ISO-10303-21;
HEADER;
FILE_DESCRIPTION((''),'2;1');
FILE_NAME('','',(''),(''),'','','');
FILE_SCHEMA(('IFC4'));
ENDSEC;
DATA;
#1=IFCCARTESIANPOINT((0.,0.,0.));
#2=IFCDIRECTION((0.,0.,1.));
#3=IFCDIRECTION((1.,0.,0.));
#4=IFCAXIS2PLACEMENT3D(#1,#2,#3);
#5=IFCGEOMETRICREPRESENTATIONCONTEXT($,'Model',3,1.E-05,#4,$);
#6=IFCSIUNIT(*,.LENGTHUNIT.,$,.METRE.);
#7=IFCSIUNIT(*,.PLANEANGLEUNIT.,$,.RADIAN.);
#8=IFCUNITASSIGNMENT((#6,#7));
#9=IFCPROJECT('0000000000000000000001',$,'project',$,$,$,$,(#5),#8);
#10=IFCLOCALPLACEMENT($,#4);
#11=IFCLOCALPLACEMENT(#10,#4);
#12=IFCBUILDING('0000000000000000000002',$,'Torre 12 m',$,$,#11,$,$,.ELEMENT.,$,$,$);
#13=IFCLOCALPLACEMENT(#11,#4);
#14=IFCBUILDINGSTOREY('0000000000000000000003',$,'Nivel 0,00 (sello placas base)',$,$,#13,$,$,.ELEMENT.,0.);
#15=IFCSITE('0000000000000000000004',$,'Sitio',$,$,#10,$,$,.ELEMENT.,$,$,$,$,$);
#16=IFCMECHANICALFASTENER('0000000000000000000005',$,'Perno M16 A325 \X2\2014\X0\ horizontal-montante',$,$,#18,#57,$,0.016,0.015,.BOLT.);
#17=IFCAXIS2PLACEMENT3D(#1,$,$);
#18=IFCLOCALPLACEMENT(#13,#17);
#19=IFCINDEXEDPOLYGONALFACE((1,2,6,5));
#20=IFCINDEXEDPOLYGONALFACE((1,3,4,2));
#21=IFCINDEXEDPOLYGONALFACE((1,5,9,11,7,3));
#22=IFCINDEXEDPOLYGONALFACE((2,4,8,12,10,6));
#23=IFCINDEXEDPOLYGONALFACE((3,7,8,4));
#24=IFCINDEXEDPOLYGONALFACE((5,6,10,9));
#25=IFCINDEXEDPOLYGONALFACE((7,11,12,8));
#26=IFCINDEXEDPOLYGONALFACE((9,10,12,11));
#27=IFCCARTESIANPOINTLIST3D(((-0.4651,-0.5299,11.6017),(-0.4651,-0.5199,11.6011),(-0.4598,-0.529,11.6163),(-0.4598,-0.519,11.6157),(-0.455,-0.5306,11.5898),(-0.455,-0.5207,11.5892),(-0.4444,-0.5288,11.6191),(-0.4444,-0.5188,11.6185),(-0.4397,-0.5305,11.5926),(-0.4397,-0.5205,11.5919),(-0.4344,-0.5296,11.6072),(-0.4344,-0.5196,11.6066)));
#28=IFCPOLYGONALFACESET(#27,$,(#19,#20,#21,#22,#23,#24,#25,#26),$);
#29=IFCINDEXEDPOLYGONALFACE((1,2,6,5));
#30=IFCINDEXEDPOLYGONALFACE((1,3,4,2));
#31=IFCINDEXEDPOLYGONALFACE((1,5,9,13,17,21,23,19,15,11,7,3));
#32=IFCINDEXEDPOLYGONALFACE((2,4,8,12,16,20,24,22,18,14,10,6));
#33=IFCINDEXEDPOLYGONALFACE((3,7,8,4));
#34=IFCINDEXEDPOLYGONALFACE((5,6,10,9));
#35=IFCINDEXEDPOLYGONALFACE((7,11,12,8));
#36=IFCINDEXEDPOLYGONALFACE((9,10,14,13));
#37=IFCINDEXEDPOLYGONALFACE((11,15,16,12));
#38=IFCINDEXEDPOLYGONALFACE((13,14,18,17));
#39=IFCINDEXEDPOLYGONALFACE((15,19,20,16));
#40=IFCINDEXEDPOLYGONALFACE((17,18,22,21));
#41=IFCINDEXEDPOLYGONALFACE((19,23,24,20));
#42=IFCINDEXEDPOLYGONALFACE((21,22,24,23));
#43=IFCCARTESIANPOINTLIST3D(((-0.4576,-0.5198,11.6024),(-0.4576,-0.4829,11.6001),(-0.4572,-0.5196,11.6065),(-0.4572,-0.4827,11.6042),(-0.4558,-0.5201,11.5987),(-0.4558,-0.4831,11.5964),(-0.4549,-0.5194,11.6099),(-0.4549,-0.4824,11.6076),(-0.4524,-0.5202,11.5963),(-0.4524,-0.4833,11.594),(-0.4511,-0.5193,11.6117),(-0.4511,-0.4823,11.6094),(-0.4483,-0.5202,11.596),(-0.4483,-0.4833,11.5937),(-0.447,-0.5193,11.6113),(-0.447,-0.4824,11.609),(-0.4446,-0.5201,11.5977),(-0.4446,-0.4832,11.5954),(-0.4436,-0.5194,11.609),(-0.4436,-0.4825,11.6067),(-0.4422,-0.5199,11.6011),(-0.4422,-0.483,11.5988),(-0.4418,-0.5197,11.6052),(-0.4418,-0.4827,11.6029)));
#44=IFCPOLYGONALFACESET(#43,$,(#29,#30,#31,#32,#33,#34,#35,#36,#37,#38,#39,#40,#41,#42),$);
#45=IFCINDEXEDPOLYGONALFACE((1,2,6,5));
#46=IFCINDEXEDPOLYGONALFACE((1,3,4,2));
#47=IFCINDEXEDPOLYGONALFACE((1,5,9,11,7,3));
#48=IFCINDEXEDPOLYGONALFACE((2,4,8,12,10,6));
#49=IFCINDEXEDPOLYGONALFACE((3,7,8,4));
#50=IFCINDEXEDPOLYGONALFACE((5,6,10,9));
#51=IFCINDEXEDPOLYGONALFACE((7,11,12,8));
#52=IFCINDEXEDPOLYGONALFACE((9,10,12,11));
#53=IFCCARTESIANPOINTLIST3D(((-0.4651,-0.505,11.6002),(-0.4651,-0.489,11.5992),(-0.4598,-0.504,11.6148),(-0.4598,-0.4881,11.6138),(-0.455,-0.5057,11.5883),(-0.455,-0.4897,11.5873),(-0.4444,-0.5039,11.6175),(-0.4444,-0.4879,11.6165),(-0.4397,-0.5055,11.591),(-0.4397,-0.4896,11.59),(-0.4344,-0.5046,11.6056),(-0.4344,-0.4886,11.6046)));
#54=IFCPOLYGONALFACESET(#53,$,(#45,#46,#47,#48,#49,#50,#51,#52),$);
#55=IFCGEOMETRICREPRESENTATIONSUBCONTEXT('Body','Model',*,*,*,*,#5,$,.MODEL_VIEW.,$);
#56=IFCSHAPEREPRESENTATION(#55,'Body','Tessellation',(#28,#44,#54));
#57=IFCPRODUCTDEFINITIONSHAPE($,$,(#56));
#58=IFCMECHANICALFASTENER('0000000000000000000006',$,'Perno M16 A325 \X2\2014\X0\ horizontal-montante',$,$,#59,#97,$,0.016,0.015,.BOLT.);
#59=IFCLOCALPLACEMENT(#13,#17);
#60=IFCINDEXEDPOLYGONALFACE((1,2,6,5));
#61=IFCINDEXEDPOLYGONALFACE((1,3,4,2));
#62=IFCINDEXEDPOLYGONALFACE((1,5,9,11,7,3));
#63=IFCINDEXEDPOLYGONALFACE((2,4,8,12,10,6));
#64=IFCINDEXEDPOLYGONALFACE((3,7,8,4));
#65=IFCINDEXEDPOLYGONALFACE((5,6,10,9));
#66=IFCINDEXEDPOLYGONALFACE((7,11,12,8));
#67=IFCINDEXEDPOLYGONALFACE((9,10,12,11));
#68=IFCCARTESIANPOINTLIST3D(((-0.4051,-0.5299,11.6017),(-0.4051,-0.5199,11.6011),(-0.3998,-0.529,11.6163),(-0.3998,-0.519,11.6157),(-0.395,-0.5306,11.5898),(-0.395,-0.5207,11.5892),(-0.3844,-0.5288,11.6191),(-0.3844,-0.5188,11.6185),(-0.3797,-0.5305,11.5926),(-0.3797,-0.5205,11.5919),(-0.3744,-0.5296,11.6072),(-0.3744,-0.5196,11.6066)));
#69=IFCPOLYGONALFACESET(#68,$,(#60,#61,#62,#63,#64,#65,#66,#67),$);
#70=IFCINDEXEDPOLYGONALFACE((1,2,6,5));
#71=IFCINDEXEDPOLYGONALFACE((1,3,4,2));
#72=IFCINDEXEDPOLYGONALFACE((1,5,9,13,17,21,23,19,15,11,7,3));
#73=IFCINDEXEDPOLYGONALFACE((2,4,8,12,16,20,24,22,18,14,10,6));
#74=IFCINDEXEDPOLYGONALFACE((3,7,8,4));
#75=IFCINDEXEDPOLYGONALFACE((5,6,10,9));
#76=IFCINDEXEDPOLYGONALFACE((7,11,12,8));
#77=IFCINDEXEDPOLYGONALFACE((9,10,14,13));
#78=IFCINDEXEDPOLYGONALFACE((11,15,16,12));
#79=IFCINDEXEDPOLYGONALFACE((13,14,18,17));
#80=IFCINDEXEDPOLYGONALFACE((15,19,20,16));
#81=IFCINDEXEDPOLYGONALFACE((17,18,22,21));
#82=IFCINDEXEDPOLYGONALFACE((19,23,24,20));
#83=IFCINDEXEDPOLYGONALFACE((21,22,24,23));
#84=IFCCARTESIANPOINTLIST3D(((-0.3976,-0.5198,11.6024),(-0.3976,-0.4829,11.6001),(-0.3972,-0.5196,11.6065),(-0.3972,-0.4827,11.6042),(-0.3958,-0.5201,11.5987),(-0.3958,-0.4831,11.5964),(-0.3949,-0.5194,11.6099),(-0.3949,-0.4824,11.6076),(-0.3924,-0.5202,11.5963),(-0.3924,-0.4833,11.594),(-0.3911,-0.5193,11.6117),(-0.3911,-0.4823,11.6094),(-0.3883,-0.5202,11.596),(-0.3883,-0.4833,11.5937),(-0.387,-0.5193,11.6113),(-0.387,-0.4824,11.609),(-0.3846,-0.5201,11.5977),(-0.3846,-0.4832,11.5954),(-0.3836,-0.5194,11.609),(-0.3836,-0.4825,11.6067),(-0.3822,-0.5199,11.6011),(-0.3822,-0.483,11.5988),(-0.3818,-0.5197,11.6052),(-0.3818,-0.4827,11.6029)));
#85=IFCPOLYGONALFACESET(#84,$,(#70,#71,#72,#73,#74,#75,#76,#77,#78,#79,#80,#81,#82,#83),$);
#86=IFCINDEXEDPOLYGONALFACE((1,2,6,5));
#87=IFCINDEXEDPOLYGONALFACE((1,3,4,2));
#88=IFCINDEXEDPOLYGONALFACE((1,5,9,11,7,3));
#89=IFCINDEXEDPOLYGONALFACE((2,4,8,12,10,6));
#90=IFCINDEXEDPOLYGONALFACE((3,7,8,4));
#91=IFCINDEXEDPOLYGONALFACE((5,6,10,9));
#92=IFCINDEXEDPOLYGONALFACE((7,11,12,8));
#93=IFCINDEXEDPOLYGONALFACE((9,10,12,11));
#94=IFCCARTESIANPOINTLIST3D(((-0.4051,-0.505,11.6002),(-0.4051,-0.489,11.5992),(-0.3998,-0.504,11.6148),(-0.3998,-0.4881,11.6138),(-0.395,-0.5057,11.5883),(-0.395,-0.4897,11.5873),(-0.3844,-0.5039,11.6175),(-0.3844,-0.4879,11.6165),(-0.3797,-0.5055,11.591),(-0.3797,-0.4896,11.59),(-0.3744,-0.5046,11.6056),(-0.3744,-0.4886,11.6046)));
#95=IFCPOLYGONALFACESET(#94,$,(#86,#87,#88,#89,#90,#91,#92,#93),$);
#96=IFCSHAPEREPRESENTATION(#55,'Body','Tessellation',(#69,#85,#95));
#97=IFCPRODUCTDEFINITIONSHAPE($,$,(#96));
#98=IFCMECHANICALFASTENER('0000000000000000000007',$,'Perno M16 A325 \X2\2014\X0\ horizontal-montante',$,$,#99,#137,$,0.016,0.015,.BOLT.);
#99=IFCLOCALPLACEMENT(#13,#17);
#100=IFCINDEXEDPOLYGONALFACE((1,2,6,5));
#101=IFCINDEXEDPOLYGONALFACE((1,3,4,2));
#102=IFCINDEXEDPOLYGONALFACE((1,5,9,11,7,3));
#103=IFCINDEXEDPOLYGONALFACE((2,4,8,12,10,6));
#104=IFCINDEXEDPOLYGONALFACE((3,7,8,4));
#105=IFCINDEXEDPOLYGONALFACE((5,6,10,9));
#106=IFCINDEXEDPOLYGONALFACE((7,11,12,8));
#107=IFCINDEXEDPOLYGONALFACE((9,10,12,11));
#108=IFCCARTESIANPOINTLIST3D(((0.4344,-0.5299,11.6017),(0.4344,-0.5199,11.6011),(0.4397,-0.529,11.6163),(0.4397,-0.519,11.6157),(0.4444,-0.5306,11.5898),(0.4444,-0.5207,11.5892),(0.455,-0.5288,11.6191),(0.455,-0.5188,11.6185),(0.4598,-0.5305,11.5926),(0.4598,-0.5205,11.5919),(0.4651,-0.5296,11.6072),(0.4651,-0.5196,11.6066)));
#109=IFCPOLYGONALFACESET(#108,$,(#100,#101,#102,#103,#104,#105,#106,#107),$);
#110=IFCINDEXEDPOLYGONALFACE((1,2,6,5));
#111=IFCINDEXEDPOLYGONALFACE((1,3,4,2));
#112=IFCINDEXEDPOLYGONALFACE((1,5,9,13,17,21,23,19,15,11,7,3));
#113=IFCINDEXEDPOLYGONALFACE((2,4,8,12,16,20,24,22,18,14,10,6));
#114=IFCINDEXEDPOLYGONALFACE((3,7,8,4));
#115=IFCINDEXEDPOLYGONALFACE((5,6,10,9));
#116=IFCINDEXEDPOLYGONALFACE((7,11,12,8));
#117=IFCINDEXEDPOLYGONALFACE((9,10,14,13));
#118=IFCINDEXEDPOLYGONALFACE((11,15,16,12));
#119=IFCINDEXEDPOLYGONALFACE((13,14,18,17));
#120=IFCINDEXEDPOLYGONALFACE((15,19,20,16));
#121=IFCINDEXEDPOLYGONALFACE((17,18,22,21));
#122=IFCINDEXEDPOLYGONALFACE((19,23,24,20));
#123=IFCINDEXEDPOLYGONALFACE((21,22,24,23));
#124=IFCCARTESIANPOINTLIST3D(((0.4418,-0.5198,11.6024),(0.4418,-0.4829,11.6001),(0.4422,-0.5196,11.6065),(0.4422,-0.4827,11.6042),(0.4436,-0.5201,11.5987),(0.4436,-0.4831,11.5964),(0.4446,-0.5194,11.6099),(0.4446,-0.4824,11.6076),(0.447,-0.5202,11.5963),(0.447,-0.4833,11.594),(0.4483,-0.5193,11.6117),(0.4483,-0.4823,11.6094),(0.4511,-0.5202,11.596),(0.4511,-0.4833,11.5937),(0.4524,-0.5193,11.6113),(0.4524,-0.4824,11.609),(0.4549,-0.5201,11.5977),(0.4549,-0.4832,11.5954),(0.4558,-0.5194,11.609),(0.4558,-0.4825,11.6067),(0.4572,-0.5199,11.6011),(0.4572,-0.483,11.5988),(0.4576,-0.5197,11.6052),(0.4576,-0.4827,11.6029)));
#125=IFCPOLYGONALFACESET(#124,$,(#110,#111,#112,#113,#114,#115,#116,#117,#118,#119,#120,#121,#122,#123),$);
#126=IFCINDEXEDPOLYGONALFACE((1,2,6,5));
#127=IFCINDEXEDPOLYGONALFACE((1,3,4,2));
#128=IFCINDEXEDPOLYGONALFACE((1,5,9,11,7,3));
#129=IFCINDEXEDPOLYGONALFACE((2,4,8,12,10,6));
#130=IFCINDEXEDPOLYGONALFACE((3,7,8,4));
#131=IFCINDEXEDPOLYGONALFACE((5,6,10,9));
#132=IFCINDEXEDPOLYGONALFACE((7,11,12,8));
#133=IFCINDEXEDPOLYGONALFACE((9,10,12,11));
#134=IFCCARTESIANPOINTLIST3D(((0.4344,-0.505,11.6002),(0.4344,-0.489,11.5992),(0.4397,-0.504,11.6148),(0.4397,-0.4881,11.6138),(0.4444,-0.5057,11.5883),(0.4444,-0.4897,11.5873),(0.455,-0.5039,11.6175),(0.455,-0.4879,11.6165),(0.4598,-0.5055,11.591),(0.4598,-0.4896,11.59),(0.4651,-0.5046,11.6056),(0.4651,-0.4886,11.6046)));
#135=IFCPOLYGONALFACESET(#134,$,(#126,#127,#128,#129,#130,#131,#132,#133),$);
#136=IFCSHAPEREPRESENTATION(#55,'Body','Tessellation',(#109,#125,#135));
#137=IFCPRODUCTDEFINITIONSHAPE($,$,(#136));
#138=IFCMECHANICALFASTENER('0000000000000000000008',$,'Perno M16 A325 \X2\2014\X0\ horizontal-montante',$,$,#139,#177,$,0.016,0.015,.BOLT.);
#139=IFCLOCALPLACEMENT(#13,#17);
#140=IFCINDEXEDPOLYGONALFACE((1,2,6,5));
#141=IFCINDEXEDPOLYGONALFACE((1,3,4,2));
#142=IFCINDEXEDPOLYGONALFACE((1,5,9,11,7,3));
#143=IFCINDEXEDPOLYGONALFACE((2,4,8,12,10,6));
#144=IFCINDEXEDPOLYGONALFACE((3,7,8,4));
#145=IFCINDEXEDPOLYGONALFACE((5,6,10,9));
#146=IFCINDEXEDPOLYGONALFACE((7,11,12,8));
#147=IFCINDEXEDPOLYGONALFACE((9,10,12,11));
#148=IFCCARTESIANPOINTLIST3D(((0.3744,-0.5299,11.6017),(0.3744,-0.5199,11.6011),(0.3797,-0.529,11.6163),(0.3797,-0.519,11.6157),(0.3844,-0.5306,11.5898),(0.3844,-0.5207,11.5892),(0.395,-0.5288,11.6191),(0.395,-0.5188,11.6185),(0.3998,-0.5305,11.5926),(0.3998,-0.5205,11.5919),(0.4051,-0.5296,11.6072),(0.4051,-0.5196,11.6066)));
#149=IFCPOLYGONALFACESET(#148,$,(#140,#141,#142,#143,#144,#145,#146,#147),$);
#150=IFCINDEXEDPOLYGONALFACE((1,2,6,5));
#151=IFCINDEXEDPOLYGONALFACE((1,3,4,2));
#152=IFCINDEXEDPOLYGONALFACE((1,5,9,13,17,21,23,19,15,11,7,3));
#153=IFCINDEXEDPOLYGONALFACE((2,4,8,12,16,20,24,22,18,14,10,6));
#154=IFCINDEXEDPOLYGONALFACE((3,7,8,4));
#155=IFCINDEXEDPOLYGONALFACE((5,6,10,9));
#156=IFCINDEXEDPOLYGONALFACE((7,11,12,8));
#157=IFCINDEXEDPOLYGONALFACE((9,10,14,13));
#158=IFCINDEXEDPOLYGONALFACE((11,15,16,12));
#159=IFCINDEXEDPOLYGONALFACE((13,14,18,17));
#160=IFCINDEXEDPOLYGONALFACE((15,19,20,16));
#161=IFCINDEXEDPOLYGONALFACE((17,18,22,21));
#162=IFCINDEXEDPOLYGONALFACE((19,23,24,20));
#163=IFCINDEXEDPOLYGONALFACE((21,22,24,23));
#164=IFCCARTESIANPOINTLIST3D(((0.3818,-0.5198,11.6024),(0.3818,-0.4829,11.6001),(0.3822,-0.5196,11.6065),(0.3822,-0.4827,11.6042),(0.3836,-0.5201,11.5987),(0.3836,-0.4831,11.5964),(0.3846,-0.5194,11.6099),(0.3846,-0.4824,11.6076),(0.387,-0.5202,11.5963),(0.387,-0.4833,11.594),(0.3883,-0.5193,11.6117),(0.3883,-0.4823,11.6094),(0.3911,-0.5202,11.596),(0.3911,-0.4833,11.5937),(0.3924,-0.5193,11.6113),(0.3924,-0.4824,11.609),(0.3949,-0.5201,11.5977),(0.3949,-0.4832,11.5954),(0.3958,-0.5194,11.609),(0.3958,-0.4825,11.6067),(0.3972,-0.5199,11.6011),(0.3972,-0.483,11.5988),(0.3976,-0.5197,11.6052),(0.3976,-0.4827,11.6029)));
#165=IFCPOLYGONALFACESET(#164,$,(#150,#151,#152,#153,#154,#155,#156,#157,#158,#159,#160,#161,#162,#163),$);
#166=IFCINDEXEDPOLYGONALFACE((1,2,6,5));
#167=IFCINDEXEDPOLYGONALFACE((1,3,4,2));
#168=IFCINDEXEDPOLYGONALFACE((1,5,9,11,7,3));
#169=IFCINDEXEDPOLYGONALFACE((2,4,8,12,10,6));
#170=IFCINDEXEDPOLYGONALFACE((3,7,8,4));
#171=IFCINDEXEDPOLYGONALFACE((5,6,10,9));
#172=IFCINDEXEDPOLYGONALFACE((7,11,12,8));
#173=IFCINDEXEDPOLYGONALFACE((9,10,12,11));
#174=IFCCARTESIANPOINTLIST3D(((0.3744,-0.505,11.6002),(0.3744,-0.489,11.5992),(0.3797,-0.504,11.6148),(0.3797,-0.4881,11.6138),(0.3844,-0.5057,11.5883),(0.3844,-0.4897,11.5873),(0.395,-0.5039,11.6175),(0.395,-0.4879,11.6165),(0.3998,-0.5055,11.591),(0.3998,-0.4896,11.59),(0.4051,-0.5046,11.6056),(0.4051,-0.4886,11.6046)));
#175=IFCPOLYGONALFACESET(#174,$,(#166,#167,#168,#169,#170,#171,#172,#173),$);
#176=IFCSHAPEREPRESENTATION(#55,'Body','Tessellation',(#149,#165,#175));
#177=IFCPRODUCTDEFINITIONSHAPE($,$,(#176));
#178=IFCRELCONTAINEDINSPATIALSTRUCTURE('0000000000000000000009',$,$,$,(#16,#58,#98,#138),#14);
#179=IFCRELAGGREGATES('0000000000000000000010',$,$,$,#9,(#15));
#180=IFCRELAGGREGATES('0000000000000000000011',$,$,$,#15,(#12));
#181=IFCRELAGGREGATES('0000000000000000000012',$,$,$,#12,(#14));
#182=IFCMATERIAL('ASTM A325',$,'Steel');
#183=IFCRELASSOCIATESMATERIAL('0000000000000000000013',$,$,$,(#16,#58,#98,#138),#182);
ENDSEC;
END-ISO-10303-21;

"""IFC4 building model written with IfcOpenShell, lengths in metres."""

from ifc_helpers import new_model, si_unit, frame, origin_with_axes, place, context, subcontext, project, spatial, polyline, outline, extrude, material, element, save


model = new_model("IFC4")

# Units and contexts
model_context = context("Model", 3, precision=1e-05, world=origin_with_axes())
body_context = subcontext(model_context, "Body", "Model", "MODEL_VIEW")
ifc_project = project(units=[si_unit("LENGTHUNIT", "METRE"), si_unit("PLANEANGLEUNIT", "RADIAN")], contexts=[model_context])

# Site, building, storey
site_placement = place(None, origin_with_axes())
site = spatial("IfcSite", under=ifc_project, at=site_placement, Name="Sitio", CompositionType="ELEMENT")
building_placement = place(site_placement, origin_with_axes())
building = spatial("IfcBuilding", under=site, at=building_placement, Name="Torre 12 m", CompositionType="ELEMENT")
storey_placement = place(building_placement, origin_with_axes())
storey = spatial("IfcBuildingStorey", under=building, at=storey_placement, Name="Nivel 0,00 (sello placas base)", CompositionType="ELEMENT", Elevation=0.0)

# Shared definitions
placement = place(storey_placement, origin_with_axes())

# Mechanical fasteners
ifc_material_1 = material(Name="ASTM A325", Category="Steel")
element("IfcMechanicalFastener", 1, at=placement, inside=storey, material=ifc_material_1, Name="Perno M16 A325 — horizontal-montante", NominalDiameter=0.016, NominalLength=0.015, PredefinedType="BOLT", context=body_context, shape_type="SweptSolid", body=[
    extrude(outline(polyline([(0.0135, 0.0078), (0.0, 0.0156), (-0.0135, 0.0078), (-0.0135, -0.0078), (0.0, -0.0156), (0.0135, -0.0078), (0.0135, 0.0078)])), frame((-0.4497, -0.5297, 11.6044), z_axis=(0.0, 0.998053, -0.062378), x_axis=(0.940405, -0.021212, -0.339394)), (0.0, 0.0, 1.0), 0.01),
    extrude(outline(polyline([(0.008, 0.0), (0.0069, 0.004), (0.004, 0.0069), (0.0, 0.008), (-0.004, 0.0069), (-0.0069, 0.004), (-0.008, 0.0), (-0.0069, -0.004), (-0.004, -0.0069), (0.0, -0.008), (0.004, -0.0069), (0.0069, -0.004), (0.008, 0.0)])), frame((-0.4497, -0.5198, 11.6038), z_axis=(0.0, 0.998053, -0.062378), x_axis=(0.940405, -0.021212, -0.339394)), (0.0, 0.0, 1.0), 0.037),
    extrude(outline(polyline([(0.0135, 0.0078), (0.0, 0.0156), (-0.0135, 0.0078), (-0.0135, -0.0078), (0.0, -0.0156), (0.0135, -0.0078), (0.0135, 0.0078)])), frame((-0.4497, -0.5048, 11.6029), z_axis=(0.0, 0.998053, -0.062378), x_axis=(0.940405, -0.021212, -0.339394)), (0.0, 0.0, 1.0), 0.016),
])
element("IfcMechanicalFastener", 2, at=placement, inside=storey, material=ifc_material_1, Name="Perno M16 A325 — horizontal-montante", NominalDiameter=0.016, NominalLength=0.015, PredefinedType="BOLT", context=body_context, shape_type="SweptSolid", body=[
    extrude(outline(polyline([(0.0135, 0.0078), (0.0, 0.0156), (-0.0135, 0.0078), (-0.0135, -0.0078), (0.0, -0.0156), (0.0135, -0.0078), (0.0135, 0.0078)])), frame((-0.3897, -0.5297, 11.6044), z_axis=(0.0, 0.998053, -0.062378), x_axis=(0.940405, -0.021212, -0.339394)), (0.0, 0.0, 1.0), 0.01),
    extrude(outline(polyline([(0.008, 0.0), (0.0069, 0.004), (0.004, 0.0069), (0.0, 0.008), (-0.004, 0.0069), (-0.0069, 0.004), (-0.008, 0.0), (-0.0069, -0.004), (-0.004, -0.0069), (0.0, -0.008), (0.004, -0.0069), (0.0069, -0.004), (0.008, 0.0)])), frame((-0.3897, -0.5198, 11.6038), z_axis=(0.0, 0.998053, -0.062378), x_axis=(0.940405, -0.021212, -0.339394)), (0.0, 0.0, 1.0), 0.037),
    extrude(outline(polyline([(0.0135, 0.0078), (0.0, 0.0156), (-0.0135, 0.0078), (-0.0135, -0.0078), (0.0, -0.0156), (0.0135, -0.0078), (0.0135, 0.0078)])), frame((-0.3897, -0.5048, 11.6029), z_axis=(0.0, 0.998053, -0.062378), x_axis=(0.940405, -0.021212, -0.339394)), (0.0, 0.0, 1.0), 0.016),
])
element("IfcMechanicalFastener", 3, at=placement, inside=storey, material=ifc_material_1, Name="Perno M16 A325 — horizontal-montante", NominalDiameter=0.016, NominalLength=0.015, PredefinedType="BOLT", context=body_context, shape_type="SweptSolid", body=[
    extrude(outline(polyline([(0.0135, 0.0078), (0.0, 0.0156), (-0.0135, 0.0078), (-0.0135, -0.0078), (0.0, -0.0156), (0.0135, -0.0078), (0.0135, 0.0078)])), frame((0.4497, -0.5297, 11.6044), z_axis=(0.0, 0.998053, -0.062378), x_axis=(0.940405, -0.021212, -0.339394)), (0.0, 0.0, 1.0), 0.01),
    extrude(outline(polyline([(0.008, 0.0), (0.0069, 0.004), (0.004, 0.0069), (0.0, 0.008), (-0.004, 0.0069), (-0.0069, 0.004), (-0.008, 0.0), (-0.0069, -0.004), (-0.004, -0.0069), (0.0, -0.008), (0.004, -0.0069), (0.0069, -0.004), (0.008, 0.0)])), frame((0.4497, -0.5198, 11.6038), z_axis=(0.0, 0.998053, -0.062378), x_axis=(0.940405, -0.021212, -0.339394)), (0.0, 0.0, 1.0), 0.037),
    extrude(outline(polyline([(0.0135, 0.0078), (0.0, 0.0156), (-0.0135, 0.0078), (-0.0135, -0.0078), (0.0, -0.0156), (0.0135, -0.0078), (0.0135, 0.0078)])), frame((0.4497, -0.5048, 11.6029), z_axis=(0.0, 0.998053, -0.062378), x_axis=(0.940405, -0.021212, -0.339394)), (0.0, 0.0, 1.0), 0.016),
])
element("IfcMechanicalFastener", 4, at=placement, inside=storey, material=ifc_material_1, Name="Perno M16 A325 — horizontal-montante", NominalDiameter=0.016, NominalLength=0.015, PredefinedType="BOLT", context=body_context, shape_type="SweptSolid", body=[
    extrude(outline(polyline([(0.0135, 0.0078), (0.0, 0.0156), (-0.0135, 0.0078), (-0.0135, -0.0078), (0.0, -0.0156), (0.0135, -0.0078), (0.0135, 0.0078)])), frame((0.3897, -0.5297, 11.6044), z_axis=(0.0, 0.998053, -0.062378), x_axis=(0.940405, -0.021212, -0.339394)), (0.0, 0.0, 1.0), 0.01),
    extrude(outline(polyline([(0.008, 0.0), (0.0069, 0.004), (0.004, 0.0069), (0.0, 0.008), (-0.004, 0.0069), (-0.0069, 0.004), (-0.008, 0.0), (-0.0069, -0.004), (-0.004, -0.0069), (0.0, -0.008), (0.004, -0.0069), (0.0069, -0.004), (0.008, 0.0)])), frame((0.3897, -0.5198, 11.6038), z_axis=(0.0, 0.998053, -0.062378), x_axis=(0.940405, -0.021212, -0.339394)), (0.0, 0.0, 1.0), 0.037),
    extrude(outline(polyline([(0.0135, 0.0078), (0.0, 0.0156), (-0.0135, 0.0078), (-0.0135, -0.0078), (0.0, -0.0156), (0.0135, -0.0078), (0.0135, 0.0078)])), frame((0.3897, -0.5048, 11.6029), z_axis=(0.0, 0.998053, -0.062378), x_axis=(0.940405, -0.021212, -0.339394)), (0.0, 0.0, 1.0), 0.016),
])

save(model, "model.ifc")
